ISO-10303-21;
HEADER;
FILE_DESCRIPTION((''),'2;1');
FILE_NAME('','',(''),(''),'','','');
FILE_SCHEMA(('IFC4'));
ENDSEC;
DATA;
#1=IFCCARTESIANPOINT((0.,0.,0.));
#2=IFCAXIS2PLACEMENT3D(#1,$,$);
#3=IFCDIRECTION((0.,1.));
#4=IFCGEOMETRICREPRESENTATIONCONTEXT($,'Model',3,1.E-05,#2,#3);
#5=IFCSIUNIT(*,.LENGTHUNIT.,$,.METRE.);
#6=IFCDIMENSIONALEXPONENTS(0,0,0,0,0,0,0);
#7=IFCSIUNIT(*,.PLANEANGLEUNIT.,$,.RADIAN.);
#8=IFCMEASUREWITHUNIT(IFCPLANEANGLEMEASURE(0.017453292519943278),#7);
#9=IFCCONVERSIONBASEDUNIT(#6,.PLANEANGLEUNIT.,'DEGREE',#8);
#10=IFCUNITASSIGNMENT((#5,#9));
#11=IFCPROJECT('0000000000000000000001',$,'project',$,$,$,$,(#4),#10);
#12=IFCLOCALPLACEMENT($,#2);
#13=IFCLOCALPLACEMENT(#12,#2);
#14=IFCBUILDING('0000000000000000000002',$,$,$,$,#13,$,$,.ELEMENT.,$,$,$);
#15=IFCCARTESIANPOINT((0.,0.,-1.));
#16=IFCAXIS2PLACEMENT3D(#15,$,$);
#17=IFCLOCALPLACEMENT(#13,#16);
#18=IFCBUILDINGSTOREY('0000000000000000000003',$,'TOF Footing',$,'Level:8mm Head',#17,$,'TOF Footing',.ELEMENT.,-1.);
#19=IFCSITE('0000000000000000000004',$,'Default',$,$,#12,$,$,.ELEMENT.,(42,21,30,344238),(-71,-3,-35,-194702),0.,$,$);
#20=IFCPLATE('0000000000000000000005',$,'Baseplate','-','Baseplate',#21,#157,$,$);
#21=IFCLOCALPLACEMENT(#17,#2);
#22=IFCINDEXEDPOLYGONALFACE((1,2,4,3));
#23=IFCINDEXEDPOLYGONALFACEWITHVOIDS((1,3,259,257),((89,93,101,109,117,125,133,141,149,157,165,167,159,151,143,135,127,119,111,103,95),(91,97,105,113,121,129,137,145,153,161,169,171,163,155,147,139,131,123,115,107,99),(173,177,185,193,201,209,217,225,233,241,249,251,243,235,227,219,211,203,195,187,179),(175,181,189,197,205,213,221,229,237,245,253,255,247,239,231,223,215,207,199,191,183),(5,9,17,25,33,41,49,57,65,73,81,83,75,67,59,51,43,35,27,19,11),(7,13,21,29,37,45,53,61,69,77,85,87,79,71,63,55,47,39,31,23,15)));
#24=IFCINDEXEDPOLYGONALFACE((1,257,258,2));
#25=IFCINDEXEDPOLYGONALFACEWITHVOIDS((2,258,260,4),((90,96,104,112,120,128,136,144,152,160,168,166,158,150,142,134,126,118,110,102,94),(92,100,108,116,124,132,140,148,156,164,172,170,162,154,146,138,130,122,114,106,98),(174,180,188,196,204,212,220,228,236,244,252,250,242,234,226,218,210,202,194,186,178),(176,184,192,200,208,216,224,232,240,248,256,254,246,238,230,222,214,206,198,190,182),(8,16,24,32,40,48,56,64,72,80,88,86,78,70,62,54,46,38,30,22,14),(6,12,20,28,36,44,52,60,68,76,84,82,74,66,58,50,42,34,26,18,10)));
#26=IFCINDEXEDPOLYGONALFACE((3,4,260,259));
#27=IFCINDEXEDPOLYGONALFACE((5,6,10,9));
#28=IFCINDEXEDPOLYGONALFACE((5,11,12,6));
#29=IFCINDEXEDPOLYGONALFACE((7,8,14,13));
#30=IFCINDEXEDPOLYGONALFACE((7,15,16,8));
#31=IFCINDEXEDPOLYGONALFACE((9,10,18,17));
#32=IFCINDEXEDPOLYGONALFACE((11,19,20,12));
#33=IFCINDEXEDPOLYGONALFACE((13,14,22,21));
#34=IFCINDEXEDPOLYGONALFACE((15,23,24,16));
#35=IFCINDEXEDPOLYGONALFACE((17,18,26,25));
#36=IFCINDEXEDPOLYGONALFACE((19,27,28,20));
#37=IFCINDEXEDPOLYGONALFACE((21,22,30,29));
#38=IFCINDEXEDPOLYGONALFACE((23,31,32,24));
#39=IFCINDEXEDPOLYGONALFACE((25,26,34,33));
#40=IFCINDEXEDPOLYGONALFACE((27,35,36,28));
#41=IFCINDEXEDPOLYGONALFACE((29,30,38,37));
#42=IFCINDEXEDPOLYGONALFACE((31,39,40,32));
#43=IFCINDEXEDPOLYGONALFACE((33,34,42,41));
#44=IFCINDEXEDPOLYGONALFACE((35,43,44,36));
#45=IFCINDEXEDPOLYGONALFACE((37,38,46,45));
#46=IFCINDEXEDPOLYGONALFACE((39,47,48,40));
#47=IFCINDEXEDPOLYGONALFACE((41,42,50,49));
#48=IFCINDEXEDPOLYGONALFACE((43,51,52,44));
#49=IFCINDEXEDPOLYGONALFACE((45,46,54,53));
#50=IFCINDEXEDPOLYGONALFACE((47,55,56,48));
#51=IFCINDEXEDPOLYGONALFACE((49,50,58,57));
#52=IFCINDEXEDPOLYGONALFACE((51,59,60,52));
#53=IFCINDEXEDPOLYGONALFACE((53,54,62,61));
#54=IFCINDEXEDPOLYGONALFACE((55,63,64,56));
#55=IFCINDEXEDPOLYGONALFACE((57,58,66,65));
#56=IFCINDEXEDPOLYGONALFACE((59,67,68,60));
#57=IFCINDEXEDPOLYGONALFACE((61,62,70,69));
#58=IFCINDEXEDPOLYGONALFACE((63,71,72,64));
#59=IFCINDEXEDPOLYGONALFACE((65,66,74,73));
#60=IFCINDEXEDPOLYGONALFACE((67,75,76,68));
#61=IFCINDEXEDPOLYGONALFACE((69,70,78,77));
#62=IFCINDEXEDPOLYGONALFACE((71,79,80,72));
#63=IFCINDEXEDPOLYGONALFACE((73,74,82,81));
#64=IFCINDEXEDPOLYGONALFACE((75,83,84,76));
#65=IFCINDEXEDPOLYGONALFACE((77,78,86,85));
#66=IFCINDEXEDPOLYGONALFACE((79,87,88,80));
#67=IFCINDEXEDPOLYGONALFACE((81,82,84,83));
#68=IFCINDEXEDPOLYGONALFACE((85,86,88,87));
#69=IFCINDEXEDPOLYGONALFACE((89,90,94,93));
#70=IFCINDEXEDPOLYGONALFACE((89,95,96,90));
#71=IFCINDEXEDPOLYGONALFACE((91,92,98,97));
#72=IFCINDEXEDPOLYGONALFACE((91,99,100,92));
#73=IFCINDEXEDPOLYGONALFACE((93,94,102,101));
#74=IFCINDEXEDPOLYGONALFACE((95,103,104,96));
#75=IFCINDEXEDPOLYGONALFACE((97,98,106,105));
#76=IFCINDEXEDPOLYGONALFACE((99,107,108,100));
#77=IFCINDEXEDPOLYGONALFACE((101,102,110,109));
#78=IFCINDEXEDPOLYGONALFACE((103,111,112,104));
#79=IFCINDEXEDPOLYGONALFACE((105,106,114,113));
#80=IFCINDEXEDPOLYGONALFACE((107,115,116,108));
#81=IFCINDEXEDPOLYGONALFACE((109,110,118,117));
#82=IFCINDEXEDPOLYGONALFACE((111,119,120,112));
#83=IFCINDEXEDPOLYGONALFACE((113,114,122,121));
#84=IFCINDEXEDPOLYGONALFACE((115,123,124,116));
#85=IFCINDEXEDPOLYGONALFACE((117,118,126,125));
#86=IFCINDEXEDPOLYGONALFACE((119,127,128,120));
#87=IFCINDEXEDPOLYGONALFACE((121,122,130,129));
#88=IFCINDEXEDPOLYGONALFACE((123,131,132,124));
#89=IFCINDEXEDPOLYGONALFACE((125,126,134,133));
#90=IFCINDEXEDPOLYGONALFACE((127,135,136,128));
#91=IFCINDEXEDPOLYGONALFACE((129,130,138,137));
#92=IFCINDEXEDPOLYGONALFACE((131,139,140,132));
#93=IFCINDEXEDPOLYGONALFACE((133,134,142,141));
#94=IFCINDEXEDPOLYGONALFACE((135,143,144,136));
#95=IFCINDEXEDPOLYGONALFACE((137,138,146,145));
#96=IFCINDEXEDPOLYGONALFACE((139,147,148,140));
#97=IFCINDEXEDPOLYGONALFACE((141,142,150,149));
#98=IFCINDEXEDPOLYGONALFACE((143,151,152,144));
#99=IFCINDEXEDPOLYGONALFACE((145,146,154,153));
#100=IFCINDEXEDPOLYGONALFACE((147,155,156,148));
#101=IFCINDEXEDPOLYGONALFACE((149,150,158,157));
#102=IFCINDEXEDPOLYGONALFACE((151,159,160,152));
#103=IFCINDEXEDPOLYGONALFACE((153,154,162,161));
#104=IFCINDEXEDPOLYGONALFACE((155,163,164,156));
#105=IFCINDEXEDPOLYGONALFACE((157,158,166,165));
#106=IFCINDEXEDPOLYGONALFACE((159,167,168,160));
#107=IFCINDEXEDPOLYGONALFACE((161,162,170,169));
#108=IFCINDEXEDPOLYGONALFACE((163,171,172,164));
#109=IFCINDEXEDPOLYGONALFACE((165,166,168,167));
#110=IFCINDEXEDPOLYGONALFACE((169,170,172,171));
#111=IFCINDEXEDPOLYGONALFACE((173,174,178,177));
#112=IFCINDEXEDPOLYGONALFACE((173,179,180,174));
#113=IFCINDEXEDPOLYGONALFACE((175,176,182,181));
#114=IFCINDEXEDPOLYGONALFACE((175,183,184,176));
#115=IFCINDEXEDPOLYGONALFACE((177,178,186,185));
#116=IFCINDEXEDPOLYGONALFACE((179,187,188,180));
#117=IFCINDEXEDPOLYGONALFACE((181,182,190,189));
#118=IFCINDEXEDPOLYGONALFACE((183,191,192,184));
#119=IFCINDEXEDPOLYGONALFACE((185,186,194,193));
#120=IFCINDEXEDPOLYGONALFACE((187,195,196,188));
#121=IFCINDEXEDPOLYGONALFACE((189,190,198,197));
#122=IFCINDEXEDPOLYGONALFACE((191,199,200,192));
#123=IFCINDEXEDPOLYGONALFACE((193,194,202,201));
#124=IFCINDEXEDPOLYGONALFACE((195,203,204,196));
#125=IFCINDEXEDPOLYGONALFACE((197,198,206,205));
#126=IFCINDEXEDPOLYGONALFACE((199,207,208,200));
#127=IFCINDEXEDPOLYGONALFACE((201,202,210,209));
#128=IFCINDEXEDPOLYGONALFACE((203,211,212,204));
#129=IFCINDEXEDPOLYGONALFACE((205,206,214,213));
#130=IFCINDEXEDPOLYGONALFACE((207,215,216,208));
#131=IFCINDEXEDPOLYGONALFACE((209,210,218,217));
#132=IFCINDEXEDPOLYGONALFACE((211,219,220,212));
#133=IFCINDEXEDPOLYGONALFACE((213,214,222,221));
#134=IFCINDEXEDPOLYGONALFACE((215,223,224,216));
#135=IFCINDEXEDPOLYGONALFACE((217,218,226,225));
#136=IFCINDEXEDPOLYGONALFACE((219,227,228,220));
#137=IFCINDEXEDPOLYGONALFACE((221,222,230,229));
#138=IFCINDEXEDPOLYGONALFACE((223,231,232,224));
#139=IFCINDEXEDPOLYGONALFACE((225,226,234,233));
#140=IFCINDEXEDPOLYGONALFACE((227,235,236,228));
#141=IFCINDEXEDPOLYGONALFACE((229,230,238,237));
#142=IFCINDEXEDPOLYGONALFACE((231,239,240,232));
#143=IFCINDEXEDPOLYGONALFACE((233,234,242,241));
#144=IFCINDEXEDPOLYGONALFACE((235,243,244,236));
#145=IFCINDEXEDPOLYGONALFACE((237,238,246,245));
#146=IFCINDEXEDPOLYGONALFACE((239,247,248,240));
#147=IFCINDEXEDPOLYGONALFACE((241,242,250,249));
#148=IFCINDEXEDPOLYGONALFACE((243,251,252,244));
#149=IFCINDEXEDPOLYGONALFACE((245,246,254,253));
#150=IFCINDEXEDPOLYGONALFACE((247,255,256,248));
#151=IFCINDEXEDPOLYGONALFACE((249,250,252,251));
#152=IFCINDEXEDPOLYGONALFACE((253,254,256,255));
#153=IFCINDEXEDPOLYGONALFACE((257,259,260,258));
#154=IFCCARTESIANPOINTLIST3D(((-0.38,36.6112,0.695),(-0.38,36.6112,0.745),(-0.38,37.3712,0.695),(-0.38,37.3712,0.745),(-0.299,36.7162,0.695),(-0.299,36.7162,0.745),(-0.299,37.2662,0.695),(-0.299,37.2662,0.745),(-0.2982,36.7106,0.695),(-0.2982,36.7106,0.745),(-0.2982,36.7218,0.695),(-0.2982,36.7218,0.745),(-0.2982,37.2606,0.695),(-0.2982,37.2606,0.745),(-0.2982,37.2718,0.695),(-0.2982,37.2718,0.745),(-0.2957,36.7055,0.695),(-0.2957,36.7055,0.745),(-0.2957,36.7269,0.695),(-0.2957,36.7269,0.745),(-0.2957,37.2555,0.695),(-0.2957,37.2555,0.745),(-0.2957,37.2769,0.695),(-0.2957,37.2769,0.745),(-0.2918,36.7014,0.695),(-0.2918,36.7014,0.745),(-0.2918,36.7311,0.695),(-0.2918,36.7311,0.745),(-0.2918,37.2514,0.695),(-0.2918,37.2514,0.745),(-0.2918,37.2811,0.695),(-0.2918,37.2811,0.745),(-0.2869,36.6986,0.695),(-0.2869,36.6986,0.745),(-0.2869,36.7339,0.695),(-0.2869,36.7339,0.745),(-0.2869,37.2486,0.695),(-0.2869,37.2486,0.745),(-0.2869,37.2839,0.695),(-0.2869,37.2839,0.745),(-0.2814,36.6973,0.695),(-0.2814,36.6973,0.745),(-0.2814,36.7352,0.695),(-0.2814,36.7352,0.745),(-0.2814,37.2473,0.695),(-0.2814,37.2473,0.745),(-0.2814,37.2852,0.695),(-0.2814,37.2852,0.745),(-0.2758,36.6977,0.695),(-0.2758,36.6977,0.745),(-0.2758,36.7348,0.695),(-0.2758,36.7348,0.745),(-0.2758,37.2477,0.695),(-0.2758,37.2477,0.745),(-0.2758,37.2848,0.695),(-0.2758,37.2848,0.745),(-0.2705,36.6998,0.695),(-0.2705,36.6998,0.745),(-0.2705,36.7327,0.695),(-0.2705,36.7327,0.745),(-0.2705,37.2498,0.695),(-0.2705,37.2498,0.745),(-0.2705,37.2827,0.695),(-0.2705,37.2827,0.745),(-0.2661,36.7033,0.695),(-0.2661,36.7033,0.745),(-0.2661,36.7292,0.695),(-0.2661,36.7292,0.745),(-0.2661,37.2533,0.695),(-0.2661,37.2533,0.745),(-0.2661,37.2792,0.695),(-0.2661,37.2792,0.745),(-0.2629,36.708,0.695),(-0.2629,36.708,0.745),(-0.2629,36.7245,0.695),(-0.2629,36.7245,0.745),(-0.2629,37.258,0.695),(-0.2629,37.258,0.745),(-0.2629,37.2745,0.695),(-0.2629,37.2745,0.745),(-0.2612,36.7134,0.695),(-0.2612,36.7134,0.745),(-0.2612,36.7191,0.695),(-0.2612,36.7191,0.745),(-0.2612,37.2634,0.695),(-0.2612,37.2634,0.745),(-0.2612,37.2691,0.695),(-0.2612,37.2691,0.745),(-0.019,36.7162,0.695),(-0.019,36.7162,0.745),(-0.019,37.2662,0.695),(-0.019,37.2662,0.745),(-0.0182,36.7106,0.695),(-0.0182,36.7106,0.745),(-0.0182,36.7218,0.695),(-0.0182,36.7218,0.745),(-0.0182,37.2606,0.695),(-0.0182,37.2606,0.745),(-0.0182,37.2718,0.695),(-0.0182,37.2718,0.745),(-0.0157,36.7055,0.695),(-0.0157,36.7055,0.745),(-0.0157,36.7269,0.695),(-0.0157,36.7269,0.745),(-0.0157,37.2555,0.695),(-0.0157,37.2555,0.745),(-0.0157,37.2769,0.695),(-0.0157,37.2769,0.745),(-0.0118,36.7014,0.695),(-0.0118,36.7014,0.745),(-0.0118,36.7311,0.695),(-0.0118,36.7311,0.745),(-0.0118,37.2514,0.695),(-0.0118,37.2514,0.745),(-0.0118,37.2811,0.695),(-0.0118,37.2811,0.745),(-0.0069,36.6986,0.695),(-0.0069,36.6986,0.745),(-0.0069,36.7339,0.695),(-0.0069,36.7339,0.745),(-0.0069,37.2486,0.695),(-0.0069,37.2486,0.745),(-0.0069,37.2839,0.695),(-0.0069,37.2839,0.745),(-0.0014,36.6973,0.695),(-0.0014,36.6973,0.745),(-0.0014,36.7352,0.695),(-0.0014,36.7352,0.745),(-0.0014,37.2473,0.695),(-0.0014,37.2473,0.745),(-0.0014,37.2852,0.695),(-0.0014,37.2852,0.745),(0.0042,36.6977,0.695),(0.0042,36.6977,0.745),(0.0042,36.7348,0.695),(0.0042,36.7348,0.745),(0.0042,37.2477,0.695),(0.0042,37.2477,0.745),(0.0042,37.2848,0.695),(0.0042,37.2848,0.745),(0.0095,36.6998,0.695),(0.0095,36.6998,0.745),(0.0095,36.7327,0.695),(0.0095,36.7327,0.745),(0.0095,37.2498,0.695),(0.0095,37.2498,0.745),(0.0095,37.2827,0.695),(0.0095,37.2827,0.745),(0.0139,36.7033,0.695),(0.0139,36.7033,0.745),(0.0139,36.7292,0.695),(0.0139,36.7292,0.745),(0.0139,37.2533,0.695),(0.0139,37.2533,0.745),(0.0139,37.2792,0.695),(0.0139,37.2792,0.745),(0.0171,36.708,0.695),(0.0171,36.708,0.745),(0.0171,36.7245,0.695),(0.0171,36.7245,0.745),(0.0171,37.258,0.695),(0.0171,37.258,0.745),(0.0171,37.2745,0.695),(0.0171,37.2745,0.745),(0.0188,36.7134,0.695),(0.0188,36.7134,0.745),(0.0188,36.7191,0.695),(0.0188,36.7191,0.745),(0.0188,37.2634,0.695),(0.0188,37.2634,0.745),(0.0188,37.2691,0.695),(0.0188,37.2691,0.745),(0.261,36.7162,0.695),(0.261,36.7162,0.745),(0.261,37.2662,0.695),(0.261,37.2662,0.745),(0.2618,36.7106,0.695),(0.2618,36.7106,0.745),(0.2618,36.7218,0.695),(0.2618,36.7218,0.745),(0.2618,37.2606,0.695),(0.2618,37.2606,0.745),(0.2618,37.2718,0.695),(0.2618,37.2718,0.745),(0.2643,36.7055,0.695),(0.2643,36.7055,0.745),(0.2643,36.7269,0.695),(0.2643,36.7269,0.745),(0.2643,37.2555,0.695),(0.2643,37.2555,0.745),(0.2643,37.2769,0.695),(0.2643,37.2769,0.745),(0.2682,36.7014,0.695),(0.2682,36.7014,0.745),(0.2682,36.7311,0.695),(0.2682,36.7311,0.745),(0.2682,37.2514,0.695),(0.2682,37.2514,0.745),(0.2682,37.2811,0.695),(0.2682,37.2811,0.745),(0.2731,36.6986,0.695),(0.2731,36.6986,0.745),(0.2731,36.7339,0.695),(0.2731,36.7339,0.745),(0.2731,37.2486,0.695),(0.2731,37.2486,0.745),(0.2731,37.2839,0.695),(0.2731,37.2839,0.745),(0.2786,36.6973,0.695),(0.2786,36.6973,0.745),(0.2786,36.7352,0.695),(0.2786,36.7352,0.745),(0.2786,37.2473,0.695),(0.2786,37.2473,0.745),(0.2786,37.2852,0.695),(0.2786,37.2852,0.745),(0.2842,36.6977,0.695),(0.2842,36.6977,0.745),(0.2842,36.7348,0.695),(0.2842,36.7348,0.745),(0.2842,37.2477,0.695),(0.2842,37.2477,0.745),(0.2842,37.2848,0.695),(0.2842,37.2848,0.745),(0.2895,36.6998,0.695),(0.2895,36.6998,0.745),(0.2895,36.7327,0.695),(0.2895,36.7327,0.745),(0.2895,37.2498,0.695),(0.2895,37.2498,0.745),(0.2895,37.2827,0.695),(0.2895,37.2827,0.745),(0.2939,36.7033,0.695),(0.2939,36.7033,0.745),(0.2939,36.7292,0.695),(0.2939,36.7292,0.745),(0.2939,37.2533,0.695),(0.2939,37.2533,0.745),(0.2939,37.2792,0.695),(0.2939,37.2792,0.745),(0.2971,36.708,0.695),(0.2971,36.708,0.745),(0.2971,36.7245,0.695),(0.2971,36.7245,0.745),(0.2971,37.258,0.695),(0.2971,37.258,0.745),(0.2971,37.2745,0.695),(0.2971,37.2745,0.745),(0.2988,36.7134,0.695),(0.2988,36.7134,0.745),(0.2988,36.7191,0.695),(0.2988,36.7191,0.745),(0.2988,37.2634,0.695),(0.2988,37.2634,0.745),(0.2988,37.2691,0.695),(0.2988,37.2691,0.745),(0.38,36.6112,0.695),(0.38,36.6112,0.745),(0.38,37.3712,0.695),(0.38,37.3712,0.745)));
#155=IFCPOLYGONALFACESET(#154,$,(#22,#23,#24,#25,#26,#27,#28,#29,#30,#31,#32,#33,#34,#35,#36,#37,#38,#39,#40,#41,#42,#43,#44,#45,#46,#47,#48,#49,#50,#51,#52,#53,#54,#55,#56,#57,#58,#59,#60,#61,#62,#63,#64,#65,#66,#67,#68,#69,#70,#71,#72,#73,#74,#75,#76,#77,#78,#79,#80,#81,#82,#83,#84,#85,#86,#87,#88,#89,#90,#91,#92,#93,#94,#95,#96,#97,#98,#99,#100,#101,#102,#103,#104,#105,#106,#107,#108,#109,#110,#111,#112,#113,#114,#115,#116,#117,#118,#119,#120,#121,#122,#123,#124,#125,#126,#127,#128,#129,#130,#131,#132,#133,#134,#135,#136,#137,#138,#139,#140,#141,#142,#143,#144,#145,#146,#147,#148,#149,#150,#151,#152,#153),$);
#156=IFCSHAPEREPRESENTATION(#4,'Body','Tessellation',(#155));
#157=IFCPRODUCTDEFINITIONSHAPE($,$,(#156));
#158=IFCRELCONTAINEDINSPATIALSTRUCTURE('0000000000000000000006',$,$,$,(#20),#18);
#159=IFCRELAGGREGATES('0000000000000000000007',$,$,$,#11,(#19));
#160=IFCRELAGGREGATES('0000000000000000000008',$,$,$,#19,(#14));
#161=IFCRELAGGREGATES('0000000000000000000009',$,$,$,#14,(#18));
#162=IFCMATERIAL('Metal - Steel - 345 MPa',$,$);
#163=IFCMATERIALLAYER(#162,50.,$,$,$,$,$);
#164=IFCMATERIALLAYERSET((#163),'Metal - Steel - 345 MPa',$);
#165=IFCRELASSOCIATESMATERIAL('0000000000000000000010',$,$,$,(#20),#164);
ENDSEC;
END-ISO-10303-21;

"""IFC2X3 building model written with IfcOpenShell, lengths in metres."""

from ifc_helpers import new_model, entity, si_unit, converted_unit, direction, frame, frame_2d, origin, origin_with_axes, place, context, project, spatial, polyline, circle, outline, extrude, material, layer, layer_set, element, save


model = new_model("IFC2X3")

# Units and contexts
model_context = context("Model", 3, precision=1e-05, world=origin(), true_north=direction((0.0, 1.0)))
ifc_project = project(units=[si_unit("LENGTHUNIT", "METRE"), converted_unit("PLANEANGLEUNIT", "DEGREE", entity("IfcPlaneAngleMeasure", 0.017453292519943278), si_unit("PLANEANGLEUNIT", "RADIAN"), dimensions=[0, 0, 0, 0, 0, 0, 0])], contexts=[model_context])

# Site, building, storey
site_placement = place(None, origin())
site = spatial("IfcSite", under=ifc_project, at=site_placement, Name="Default", CompositionType="ELEMENT", RefLatitude=(42, 21, 30, 344238), RefLongitude=(-71, -3, -35, -194702), RefElevation=0.0)
building_placement = place(site_placement, origin())
building = spatial("IfcBuilding", under=site, at=building_placement, CompositionType="ELEMENT")
storey_placement = place(building_placement, frame((0.0, 0.0, -1.0)))
storey = spatial("IfcBuildingStorey", under=building, at=storey_placement, Name="TOF Footing", ObjectType="Level:8mm Head", LongName="TOF Footing", CompositionType="ELEMENT", Elevation=-1.0)

# Plate, openings
ifc_material_1 = material(Name="Metal - Steel - 345 MPa")
ifc_layer = layer(ifc_material_1, 50.0)
ifc_layer_set = layer_set([ifc_layer], Name="Metal - Steel - 345 MPa")
plate_1_placement = place(storey_placement, frame((0.38, 36.6112, 0.745), z_axis=(0.0, 0.0, -1.0), x_axis=(-1.0, 0.0, 0.0)))
plate_1 = element("IfcPlate", 1, at=plate_1_placement, inside=storey, material=ifc_layer_set, Name="Baseplate", Description="-", ObjectType="Baseplate", context=model_context, shape_type="SweptSolid", body=[
    extrude(outline(polyline([(0.0, 0.0), (0.76, 0.0), (0.76, 0.76), (0.0, 0.76), (0.0, 0.0)])), origin_with_axes(), (0.0, 0.0, 1.0), 0.05),
])
opening_1_placement = place(plate_1_placement, frame((0.38, 0.38, 0.0505), z_axis=(0.0, 0.0, -1.0), x_axis=(1.0, 0.0, 0.0)))
element("IfcOpeningElement", 2, at=opening_1_placement, cuts=plate_1, ObjectType="Opening", context=model_context, shape_type="SweptSolid", body=[
    extrude(circle(Radius=0.019, at=frame_2d((0.0, 0.275), x_axis=(1.0, 0.0))), origin(), (0.0, 0.0, 1.0), 0.051),
])
opening_2_placement = place(plate_1_placement, frame((0.38, 0.38, 0.0505), z_axis=(0.0, 0.0, -1.0), x_axis=(1.0, 0.0, 0.0)))
element("IfcOpeningElement", 3, at=opening_2_placement, cuts=plate_1, ObjectType="Opening", context=model_context, shape_type="SweptSolid", body=[
    extrude(circle(Radius=0.019, at=frame_2d((0.28, 0.275), x_axis=(1.0, 0.0))), origin(), (0.0, 0.0, 1.0), 0.051),
])
opening_3_placement = place(plate_1_placement, frame((0.38, 0.38, 0.0505), z_axis=(0.0, 0.0, -1.0), x_axis=(1.0, 0.0, 0.0)))
element("IfcOpeningElement", 4, at=opening_3_placement, cuts=plate_1, ObjectType="Opening", context=model_context, shape_type="SweptSolid", body=[
    extrude(circle(Radius=0.019, at=frame_2d((-0.28, 0.275), x_axis=(1.0, 0.0))), origin(), (0.0, 0.0, 1.0), 0.051),
])
opening_4_placement = place(plate_1_placement, frame((0.38, 0.38, 0.0505), z_axis=(0.0, 0.0, -1.0), x_axis=(1.0, 0.0, 0.0)))
element("IfcOpeningElement", 5, at=opening_4_placement, cuts=plate_1, ObjectType="Opening", context=model_context, shape_type="SweptSolid", body=[
    extrude(circle(Radius=0.019, at=frame_2d((0.0, -0.275), x_axis=(1.0, 0.0))), origin(), (0.0, 0.0, 1.0), 0.051),
])
opening_5_placement = place(plate_1_placement, frame((0.38, 0.38, 0.0505), z_axis=(0.0, 0.0, -1.0), x_axis=(1.0, 0.0, 0.0)))
element("IfcOpeningElement", 6, at=opening_5_placement, cuts=plate_1, ObjectType="Opening", context=model_context, shape_type="SweptSolid", body=[
    extrude(circle(Radius=0.019, at=frame_2d((0.28, -0.275), x_axis=(1.0, 0.0))), origin(), (0.0, 0.0, 1.0), 0.051),
])
opening_6_placement = place(plate_1_placement, frame((0.38, 0.38, 0.0505), z_axis=(0.0, 0.0, -1.0), x_axis=(1.0, 0.0, 0.0)))
element("IfcOpeningElement", 7, at=opening_6_placement, cuts=plate_1, ObjectType="Opening", context=model_context, shape_type="SweptSolid", body=[
    extrude(circle(Radius=0.019, at=frame_2d((-0.28, -0.275), x_axis=(1.0, 0.0))), origin(), (0.0, 0.0, 1.0), 0.051),
])

save(model, "model.ifc")
